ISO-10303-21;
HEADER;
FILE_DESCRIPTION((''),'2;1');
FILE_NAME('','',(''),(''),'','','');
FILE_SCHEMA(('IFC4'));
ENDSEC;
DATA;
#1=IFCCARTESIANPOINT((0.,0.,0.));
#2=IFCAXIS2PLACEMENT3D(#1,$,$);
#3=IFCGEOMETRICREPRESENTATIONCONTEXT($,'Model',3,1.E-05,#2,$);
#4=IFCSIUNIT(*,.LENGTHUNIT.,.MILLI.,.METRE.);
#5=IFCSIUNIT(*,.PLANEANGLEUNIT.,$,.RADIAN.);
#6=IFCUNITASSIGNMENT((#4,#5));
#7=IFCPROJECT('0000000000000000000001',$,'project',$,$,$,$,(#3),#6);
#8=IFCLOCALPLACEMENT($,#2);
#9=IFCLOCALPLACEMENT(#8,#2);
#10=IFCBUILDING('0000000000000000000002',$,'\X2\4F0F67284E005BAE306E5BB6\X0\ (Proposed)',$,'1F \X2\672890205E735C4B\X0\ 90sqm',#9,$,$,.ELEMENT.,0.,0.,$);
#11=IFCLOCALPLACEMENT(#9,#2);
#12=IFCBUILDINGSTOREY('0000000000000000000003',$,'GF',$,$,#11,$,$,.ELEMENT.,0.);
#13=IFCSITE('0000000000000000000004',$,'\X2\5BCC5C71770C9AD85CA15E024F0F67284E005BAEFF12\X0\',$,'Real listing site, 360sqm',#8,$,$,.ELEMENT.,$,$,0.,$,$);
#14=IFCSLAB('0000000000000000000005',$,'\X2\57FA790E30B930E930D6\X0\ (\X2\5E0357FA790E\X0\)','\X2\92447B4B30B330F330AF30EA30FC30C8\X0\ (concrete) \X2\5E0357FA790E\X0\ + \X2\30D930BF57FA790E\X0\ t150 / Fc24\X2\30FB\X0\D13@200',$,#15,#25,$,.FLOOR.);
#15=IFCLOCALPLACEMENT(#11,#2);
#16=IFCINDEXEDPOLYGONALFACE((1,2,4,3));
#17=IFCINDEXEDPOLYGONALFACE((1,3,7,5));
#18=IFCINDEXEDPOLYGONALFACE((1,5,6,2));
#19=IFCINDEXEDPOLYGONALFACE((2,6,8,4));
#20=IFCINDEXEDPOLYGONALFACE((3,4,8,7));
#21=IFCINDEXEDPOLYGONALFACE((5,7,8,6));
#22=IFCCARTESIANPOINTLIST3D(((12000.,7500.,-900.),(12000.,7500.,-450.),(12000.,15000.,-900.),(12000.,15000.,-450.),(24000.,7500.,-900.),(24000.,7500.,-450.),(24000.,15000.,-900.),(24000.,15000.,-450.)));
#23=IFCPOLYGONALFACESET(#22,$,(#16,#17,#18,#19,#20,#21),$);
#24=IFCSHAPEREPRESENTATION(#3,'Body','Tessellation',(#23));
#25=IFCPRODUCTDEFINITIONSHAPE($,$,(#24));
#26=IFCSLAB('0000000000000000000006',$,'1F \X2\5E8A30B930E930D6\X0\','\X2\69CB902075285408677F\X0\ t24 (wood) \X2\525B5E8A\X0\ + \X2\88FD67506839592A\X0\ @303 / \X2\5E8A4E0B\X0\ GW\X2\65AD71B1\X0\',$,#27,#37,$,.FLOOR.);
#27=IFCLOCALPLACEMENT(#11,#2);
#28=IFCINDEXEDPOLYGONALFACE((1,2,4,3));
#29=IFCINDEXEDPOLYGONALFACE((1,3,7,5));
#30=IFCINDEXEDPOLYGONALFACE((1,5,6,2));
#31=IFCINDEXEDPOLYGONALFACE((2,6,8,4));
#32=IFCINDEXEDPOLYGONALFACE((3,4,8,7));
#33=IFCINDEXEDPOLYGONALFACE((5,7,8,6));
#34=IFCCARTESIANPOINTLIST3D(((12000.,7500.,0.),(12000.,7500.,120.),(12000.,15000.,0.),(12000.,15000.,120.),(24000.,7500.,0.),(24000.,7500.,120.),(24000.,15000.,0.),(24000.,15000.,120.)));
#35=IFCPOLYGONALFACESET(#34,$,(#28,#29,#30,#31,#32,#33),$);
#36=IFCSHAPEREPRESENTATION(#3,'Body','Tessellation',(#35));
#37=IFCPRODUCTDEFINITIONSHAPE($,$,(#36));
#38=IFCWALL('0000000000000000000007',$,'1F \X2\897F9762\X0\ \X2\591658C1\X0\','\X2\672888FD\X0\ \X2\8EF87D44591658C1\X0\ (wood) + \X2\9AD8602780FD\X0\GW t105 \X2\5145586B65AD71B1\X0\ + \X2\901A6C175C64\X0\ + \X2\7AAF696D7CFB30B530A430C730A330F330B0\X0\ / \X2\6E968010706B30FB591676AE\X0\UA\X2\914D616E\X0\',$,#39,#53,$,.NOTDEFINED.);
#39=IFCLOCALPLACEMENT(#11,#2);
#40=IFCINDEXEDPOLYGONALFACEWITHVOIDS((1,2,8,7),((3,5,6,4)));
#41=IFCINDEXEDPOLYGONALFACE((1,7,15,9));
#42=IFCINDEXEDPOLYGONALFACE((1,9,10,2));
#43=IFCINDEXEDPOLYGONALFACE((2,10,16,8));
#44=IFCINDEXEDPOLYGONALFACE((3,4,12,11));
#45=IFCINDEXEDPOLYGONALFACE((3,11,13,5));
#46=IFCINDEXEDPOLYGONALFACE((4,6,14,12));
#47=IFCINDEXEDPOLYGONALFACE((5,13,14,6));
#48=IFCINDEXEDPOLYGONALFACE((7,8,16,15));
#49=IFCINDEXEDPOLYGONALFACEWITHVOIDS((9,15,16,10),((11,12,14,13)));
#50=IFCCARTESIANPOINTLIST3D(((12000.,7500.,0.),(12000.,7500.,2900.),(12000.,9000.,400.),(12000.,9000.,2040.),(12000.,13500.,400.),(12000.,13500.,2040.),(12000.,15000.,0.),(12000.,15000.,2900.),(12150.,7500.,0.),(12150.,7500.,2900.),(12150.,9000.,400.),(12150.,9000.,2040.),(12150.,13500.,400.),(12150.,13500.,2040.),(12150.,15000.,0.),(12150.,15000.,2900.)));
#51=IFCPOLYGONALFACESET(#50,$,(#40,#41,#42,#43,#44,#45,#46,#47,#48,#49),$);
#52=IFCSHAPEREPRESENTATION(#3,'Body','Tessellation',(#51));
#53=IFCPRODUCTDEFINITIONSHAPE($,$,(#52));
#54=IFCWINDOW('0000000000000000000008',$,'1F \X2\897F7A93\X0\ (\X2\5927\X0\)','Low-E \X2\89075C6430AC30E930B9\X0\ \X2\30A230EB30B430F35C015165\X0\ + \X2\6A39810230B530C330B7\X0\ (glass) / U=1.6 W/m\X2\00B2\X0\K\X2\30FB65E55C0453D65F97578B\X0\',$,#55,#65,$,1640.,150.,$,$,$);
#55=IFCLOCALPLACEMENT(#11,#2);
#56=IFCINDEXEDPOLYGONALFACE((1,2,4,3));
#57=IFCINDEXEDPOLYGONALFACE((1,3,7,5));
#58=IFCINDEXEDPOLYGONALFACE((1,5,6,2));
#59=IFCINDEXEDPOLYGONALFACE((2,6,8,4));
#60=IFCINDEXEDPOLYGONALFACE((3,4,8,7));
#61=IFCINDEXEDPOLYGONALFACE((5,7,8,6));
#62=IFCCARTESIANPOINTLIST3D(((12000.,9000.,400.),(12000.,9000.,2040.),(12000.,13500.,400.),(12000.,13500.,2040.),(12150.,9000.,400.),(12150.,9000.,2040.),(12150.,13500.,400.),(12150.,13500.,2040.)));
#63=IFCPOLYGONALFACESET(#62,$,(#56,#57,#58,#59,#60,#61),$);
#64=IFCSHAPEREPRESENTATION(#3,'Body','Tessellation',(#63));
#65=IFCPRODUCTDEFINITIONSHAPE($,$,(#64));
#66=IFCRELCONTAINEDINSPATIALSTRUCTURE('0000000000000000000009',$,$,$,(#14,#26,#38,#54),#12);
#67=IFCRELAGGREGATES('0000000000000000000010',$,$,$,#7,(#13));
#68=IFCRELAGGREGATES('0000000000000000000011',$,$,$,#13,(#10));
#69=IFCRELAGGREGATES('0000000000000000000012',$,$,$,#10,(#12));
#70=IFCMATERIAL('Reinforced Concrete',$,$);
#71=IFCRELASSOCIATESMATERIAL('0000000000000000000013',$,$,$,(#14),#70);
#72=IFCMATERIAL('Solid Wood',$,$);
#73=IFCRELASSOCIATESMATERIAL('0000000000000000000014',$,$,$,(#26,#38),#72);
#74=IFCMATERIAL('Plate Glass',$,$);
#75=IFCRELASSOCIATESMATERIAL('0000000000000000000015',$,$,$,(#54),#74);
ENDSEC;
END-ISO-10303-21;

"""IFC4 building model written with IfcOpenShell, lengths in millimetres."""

from ifc_helpers import new_model, si_unit, frame, frame_2d, origin, place, context, project, spatial, rectangle, extrude, material, element, fill, save


model = new_model("IFC4")

# Units and contexts
model_context = context("Model", 3, precision=1e-05, world=origin())
ifc_project = project(units=[si_unit("LENGTHUNIT", "METRE", prefix="MILLI"), si_unit("PLANEANGLEUNIT", "RADIAN")], contexts=[model_context])

# Site, building, storey
site_placement = place(None, origin())
site = spatial("IfcSite", under=ifc_project, at=site_placement, Name="富山県高岡市伏木一宮２", ObjectType="Real listing site, 360sqm", CompositionType="ELEMENT", RefElevation=0.0)
building_placement = place(site_placement, origin())
building = spatial("IfcBuilding", under=site, at=building_placement, Name="伏木一宮の家 (Proposed)", ObjectType="1F 木造平屋 90sqm", CompositionType="ELEMENT", ElevationOfRefHeight=0.0, ElevationOfTerrain=0.0)
storey_placement = place(building_placement, origin())
storey = spatial("IfcBuildingStorey", under=building, at=storey_placement, Name="GF", CompositionType="ELEMENT", Elevation=0.0)

# Slabs
ifc_material_1 = material(Name="Reinforced Concrete")
slab_1_placement = place(storey_placement, frame((6000.0, 3750.0, -450.0)))
element("IfcSlab", 1, at=slab_1_placement, inside=storey, material=ifc_material_1, Name="基礎スラブ (布基礎)", Description="鉄筋コンクリート (concrete) 布基礎 + ベタ基礎 t150 / Fc24・D13@200", PredefinedType="FLOOR", context=model_context, shape_type="SweptSolid", body=[
    extrude(rectangle(XDim=12000.0, YDim=7500.0, at=frame_2d((6000.0, 3750.0))), frame((6000.0, 3750.0, -450.0)), (0.0, 0.0, 1.0), 450.0),
])
ifc_material_2 = material(Name="Solid Wood")
slab_2_placement = place(storey_placement, frame((6000.0, 3750.0, 0.0)))
element("IfcSlab", 2, at=slab_2_placement, inside=storey, material=ifc_material_2, Name="1F 床スラブ", Description="構造用合板 t24 (wood) 剛床 + 製材根太 @303 / 床下 GW断熱", PredefinedType="FLOOR", context=model_context, shape_type="SweptSolid", body=[
    extrude(rectangle(XDim=12000.0, YDim=7500.0, at=frame_2d((6000.0, 3750.0))), frame((6000.0, 3750.0, 0.0)), (0.0, 0.0, 1.0), 120.0),
])

# Shared definitions
ifc_material_3 = material(Name="Plate Glass")

# Wall, opening, window
wall_1_placement = place(storey_placement, frame((6000.0, 3750.0, 0.0)))
wall_1 = element("IfcWall", 3, at=wall_1_placement, inside=storey, material=ifc_material_2, Name="1F 西面 外壁", Description="木製 軸組外壁 (wood) + 高性能GW t105 充填断熱 + 通気層 + 窯業系サイディング / 準耐火・外皮UA配慮", PredefinedType="NOTDEFINED", context=model_context, shape_type="SweptSolid", body=[
    extrude(rectangle(XDim=150.0, YDim=7500.0, at=frame_2d((75.0, 3750.0))), frame((6000.0, 3750.0, 0.0)), (0.0, 0.0, 1.0), 2900.0),
])
opening_1_placement = place(storey_placement, frame((6000.0, 4500.0, 200.0)))
opening_1 = element("IfcOpeningElement", 4, at=opening_1_placement, cuts=wall_1, PredefinedType="NOTDEFINED", context=model_context, shape_type="SweptSolid", body=[
    extrude(rectangle(XDim=150.0, YDim=4500.0, at=frame_2d((75.0, 2250.0))), frame((6000.0, 4500.0, 200.0)), (0.0, 0.0, 1.0), 1640.0),
])
window_1_placement = place(storey_placement, frame((6000.0, 4500.0, 200.0)))
window_1 = element("IfcWindow", 5, at=window_1_placement, inside=storey, material=ifc_material_3, Name="1F 西窓 (大)", Description="Low-E 複層ガラス アルゴン封入 + 樹脂サッシ (glass) / U=1.6 W/m²K・日射取得型", OverallHeight=1640.0, OverallWidth=150.0, context=model_context, shape_type="SweptSolid", body=[
    extrude(rectangle(XDim=150.0, YDim=4500.0, at=frame_2d((75.0, 2250.0))), frame((6000.0, 4500.0, 200.0)), (0.0, 0.0, 1.0), 1640.0),
])
fill(opening_1, window_1)

save(model, "model.ifc")
